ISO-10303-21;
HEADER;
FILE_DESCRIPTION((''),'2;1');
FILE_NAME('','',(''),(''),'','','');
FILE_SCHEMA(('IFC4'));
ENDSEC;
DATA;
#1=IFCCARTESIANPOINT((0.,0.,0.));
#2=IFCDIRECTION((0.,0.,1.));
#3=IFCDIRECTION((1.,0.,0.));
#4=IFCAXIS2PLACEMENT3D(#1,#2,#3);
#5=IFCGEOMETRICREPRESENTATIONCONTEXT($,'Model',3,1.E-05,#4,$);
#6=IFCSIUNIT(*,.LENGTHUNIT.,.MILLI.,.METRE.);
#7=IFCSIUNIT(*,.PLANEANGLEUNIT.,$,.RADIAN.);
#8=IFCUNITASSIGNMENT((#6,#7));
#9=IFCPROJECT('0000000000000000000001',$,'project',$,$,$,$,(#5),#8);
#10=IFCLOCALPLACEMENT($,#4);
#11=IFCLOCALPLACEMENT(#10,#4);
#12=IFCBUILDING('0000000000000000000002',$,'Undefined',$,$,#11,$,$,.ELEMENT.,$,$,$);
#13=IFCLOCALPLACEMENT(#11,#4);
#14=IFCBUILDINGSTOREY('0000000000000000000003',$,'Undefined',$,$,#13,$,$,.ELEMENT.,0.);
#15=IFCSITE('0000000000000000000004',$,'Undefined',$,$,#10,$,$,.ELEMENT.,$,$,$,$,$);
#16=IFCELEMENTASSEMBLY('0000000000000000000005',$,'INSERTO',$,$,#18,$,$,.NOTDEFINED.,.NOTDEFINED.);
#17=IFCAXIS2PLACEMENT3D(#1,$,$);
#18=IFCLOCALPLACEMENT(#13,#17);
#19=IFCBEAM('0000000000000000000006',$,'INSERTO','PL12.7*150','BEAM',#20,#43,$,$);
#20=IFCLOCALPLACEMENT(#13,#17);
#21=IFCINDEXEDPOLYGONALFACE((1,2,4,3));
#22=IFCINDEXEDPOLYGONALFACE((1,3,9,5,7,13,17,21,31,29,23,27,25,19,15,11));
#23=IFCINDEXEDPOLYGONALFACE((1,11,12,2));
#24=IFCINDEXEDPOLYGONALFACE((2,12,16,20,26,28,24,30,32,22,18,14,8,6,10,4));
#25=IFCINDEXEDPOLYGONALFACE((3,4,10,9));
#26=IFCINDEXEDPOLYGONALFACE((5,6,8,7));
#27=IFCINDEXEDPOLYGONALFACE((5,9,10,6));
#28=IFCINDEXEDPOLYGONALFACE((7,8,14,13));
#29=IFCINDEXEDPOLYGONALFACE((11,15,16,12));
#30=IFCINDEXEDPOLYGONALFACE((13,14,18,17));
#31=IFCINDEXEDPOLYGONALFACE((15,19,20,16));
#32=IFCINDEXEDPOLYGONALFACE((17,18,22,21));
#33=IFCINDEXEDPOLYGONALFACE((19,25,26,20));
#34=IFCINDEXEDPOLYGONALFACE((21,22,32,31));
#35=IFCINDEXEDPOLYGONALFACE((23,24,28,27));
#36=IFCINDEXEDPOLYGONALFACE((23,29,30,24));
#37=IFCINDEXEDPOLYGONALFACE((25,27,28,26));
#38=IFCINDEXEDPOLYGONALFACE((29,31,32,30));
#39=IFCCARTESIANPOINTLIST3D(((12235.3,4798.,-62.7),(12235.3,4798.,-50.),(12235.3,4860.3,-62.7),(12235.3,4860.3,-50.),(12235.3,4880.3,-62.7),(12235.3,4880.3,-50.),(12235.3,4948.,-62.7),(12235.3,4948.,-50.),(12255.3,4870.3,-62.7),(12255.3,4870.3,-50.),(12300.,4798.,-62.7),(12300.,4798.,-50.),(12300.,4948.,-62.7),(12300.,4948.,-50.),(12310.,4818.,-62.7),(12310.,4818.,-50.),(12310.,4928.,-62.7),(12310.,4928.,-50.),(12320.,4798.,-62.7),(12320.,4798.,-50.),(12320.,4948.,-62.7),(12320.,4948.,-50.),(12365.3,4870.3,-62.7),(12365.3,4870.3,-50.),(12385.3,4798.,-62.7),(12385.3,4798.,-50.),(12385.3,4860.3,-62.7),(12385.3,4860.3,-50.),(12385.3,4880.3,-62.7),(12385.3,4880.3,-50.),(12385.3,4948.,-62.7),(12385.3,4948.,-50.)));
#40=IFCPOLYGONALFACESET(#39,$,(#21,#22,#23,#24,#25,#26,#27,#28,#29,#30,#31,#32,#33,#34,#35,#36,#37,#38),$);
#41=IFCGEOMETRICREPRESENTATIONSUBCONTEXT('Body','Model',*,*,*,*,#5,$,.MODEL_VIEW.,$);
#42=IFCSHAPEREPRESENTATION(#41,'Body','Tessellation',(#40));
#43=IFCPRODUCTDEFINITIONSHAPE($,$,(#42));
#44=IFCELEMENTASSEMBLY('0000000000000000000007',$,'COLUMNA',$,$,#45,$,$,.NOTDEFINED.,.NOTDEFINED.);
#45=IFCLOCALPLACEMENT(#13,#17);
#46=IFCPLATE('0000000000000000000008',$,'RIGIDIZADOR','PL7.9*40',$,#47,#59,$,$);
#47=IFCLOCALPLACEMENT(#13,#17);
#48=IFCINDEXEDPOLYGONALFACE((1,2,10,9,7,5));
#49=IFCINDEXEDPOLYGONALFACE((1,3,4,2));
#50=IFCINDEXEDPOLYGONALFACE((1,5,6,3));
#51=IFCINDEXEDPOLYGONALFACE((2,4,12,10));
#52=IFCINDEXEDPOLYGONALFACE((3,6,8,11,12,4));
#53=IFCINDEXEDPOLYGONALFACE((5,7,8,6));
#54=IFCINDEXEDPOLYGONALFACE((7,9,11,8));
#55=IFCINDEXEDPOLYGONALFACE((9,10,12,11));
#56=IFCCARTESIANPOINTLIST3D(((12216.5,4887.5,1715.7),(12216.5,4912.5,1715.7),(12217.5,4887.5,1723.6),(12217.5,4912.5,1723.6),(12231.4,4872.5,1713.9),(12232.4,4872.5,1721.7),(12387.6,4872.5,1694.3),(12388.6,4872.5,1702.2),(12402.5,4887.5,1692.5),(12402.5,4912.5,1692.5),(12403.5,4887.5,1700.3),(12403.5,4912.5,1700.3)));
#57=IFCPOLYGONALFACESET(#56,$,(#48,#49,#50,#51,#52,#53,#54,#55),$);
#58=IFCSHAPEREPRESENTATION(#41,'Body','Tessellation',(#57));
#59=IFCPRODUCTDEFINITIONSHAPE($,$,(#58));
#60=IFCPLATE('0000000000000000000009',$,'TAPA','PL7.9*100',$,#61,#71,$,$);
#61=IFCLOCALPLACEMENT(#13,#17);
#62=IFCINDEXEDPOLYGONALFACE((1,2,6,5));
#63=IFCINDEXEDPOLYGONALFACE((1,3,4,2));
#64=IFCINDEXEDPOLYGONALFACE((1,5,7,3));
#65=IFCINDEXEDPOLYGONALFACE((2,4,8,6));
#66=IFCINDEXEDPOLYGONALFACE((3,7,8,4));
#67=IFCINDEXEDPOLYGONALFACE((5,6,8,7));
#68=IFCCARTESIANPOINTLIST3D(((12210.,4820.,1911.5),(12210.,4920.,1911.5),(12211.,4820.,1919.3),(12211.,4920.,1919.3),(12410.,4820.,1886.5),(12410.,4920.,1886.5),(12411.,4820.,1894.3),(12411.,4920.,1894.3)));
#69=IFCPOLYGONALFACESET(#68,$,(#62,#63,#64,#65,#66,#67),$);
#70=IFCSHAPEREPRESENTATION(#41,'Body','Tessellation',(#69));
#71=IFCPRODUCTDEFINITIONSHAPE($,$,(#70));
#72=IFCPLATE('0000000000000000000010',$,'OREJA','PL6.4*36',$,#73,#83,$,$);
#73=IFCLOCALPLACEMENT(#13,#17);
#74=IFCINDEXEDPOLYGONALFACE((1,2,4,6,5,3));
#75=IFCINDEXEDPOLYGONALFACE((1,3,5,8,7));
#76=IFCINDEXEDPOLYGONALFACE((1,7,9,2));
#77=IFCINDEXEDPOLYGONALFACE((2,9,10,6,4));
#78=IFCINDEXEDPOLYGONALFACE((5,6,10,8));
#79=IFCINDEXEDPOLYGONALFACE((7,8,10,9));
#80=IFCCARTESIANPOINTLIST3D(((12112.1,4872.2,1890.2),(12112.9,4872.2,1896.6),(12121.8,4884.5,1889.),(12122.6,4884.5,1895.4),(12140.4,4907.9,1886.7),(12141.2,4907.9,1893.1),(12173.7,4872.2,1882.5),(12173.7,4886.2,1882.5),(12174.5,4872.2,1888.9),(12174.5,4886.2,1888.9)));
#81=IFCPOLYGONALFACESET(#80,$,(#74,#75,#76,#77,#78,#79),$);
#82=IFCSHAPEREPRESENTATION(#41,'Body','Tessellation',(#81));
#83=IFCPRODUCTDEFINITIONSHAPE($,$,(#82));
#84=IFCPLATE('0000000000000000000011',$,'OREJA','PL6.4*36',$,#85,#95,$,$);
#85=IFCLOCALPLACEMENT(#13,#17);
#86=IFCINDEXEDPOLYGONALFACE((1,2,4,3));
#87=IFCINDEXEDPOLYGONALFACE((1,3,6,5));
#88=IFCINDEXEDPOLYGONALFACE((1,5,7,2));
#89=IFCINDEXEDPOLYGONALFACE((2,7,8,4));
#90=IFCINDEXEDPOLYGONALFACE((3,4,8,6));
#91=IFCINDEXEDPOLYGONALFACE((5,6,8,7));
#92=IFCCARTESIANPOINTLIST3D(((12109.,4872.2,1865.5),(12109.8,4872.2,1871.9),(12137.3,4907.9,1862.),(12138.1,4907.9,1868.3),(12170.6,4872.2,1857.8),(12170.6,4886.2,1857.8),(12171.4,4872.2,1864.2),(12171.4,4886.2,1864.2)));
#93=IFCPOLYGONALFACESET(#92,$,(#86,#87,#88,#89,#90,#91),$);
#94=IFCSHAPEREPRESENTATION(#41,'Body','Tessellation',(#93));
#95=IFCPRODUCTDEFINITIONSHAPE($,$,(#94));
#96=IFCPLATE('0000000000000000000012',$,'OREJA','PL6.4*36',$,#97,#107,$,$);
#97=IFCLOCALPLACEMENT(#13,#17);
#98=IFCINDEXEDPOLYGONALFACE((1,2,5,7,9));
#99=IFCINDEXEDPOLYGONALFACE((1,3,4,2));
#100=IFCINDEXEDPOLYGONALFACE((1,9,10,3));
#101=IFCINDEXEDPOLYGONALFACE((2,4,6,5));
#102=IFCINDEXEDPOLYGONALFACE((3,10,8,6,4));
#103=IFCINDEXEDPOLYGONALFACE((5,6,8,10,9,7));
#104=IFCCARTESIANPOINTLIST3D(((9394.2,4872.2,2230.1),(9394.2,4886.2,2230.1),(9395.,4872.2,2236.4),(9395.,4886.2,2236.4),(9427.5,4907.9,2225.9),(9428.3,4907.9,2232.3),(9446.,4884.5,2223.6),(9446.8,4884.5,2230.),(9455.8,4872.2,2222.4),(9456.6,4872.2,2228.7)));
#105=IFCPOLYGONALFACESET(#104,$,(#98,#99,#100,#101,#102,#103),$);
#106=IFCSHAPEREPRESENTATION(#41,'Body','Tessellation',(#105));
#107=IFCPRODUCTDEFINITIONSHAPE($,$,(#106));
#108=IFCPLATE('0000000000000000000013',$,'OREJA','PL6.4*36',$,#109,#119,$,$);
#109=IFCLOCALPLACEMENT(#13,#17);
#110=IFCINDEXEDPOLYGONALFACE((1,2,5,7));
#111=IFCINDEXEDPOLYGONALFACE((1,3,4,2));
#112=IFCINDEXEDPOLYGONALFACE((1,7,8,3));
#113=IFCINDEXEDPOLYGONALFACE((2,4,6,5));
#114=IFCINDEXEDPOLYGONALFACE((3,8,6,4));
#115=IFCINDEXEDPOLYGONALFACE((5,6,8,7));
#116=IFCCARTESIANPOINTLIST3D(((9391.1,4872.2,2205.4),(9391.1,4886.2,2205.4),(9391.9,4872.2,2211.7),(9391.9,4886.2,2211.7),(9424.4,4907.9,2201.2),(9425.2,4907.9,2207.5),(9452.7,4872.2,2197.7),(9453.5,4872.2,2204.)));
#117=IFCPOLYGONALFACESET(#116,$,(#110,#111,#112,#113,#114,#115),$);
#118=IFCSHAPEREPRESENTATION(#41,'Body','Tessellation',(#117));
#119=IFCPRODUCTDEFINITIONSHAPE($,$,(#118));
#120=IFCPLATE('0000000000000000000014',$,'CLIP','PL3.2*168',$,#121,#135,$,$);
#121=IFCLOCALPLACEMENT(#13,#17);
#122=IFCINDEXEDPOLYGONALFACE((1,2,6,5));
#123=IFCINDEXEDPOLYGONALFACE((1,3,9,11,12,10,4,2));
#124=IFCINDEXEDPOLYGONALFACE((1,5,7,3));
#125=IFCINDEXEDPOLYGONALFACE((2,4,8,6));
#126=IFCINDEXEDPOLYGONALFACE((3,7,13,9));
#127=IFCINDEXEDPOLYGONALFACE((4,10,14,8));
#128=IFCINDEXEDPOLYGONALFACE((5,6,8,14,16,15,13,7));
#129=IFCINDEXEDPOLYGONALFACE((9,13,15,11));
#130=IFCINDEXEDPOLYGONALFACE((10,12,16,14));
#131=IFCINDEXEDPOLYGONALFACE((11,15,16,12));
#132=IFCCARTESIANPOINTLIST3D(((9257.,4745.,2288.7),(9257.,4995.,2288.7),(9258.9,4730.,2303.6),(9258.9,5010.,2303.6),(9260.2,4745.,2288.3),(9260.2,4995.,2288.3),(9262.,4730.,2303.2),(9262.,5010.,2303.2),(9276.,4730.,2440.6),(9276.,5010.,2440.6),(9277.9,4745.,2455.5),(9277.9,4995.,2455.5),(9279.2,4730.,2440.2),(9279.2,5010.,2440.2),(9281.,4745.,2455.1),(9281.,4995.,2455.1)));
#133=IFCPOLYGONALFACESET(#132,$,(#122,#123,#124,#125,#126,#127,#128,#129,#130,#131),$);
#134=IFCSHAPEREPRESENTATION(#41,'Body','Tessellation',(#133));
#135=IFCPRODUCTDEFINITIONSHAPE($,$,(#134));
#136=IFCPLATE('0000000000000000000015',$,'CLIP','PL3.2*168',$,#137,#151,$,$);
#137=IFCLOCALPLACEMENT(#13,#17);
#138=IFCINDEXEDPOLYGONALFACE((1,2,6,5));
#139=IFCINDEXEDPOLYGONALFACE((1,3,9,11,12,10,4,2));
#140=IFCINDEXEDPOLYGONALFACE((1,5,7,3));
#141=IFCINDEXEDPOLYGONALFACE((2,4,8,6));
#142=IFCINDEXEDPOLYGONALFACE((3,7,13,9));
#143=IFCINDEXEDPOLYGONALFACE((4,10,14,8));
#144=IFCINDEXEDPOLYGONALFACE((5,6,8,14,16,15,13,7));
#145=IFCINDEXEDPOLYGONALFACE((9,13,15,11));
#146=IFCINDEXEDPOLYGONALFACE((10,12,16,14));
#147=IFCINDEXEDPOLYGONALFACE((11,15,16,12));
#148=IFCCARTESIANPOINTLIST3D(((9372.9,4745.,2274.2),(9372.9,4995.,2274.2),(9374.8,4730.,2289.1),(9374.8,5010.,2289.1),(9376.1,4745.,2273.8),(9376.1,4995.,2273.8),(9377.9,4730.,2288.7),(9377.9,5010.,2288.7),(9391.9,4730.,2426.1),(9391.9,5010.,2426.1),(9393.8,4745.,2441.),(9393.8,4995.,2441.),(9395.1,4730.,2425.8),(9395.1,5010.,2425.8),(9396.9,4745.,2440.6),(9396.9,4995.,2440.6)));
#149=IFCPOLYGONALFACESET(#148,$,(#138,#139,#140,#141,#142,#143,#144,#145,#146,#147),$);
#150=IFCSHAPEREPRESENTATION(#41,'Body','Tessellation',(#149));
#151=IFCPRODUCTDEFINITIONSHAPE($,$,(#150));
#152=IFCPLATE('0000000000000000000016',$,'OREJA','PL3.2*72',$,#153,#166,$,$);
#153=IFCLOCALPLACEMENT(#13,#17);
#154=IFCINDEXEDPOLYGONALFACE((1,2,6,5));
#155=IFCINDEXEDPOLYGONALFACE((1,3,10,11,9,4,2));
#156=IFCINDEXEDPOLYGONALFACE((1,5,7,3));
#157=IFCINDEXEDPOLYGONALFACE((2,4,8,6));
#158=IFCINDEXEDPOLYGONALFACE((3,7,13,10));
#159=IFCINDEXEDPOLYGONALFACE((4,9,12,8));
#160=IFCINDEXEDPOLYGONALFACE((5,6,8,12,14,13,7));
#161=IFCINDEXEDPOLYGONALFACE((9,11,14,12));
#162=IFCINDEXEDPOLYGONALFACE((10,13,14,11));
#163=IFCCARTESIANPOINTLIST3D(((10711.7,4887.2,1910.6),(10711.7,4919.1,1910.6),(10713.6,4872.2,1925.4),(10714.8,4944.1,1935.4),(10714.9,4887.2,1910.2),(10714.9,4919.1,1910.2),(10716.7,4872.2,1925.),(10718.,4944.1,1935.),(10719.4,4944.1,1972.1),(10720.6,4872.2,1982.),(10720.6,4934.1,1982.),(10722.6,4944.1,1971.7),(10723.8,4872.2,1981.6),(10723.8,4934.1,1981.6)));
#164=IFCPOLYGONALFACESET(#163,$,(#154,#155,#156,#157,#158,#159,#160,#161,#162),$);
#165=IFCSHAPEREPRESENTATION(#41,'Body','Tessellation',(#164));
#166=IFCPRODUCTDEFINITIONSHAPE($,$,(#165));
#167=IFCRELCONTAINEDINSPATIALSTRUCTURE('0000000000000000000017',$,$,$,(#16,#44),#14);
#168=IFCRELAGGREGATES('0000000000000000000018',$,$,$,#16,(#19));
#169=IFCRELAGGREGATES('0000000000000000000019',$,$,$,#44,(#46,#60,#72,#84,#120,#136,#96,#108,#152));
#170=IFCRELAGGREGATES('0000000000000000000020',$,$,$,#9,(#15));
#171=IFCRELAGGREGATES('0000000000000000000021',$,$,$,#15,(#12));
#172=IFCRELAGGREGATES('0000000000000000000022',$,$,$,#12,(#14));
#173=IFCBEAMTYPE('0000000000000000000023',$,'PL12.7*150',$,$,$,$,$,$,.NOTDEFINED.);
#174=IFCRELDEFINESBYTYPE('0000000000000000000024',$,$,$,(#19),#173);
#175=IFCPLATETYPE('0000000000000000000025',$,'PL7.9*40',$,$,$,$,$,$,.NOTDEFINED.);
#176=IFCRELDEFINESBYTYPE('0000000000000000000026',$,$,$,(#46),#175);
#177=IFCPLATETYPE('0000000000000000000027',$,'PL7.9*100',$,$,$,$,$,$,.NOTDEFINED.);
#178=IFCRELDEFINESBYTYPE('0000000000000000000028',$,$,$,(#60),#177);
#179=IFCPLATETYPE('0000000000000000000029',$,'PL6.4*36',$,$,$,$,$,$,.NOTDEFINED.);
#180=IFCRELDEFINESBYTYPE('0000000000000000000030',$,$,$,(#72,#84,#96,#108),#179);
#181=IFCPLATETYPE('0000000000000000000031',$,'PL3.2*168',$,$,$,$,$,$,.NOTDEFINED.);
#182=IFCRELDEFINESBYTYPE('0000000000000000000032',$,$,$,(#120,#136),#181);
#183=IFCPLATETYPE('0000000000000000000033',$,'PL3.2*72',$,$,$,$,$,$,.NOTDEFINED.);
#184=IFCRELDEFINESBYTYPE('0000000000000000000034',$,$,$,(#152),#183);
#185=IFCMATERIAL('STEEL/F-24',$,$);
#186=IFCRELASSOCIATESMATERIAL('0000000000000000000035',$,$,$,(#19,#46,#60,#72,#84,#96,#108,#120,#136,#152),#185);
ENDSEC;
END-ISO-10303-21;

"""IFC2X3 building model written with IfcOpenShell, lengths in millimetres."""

from ifc_helpers import new_model, si_unit, frame, origin_with_axes, origin_2d_with_axis, place, context, subcontext, project, spatial, polyline, rectangle, outline, extrude, boolean, material, type_object, element, aggregate, save


model = new_model("IFC2X3")

# Units and contexts
model_context = context("Model", 3, precision=1e-05, world=origin_with_axes())
body_context = subcontext(model_context, "Body", "Model", "MODEL_VIEW")
ifc_project = project(units=[si_unit("LENGTHUNIT", "METRE", prefix="MILLI"), si_unit("PLANEANGLEUNIT", "RADIAN")], contexts=[model_context])

# Site, building, storey
site_placement = place(None, origin_with_axes())
site = spatial("IfcSite", under=ifc_project, at=site_placement, Name="Undefined", CompositionType="ELEMENT")
building_placement = place(site_placement, origin_with_axes())
building = spatial("IfcBuilding", under=site, at=building_placement, Name="Undefined", CompositionType="ELEMENT")
storey_placement = place(building_placement, origin_with_axes())
storey = spatial("IfcBuildingStorey", under=building, at=storey_placement, Name="Undefined", CompositionType="ELEMENT", Elevation=0.0)

# Element assembly, beam
assembly_1_placement = place(storey_placement, origin_with_axes())
assembly_1 = element("IfcElementAssembly", 1, at=assembly_1_placement, inside=storey, Name="INSERTO", AssemblyPlace="NOTDEFINED", PredefinedType="NOTDEFINED")
ifc_material_1 = material(Name="STEEL/F-24")
beam_type_1 = type_object("IfcBeamType", Name="PL12.7*150", PredefinedType="NOTDEFINED")
beam_1_placement = place(assembly_1_placement, frame((12235.3, 4873.0, -56.3), z_axis=(0.0, 1.0, 0.0), x_axis=(1.0, 0.0, 0.0)))
beam_1 = element("IfcBeam", 2, at=beam_1_placement, type_object=beam_type_1, material=ifc_material_1, Name="INSERTO", Description="PL12.7*150", ObjectType="BEAM", context=body_context, shape_type="CSG", body=[
    boolean("DIFFERENCE", boolean("DIFFERENCE", boolean("DIFFERENCE", boolean("DIFFERENCE", extrude(rectangle(XDim=12.7, YDim=150.0, at=origin_2d_with_axis()), frame((150.0, 0.0, 0.0), z_axis=(-1.0, 0.0, 0.0), x_axis=(0.0, -1.0, 0.0)), (0.0, 0.0, 1.0), 150.0), extrude(outline(polyline([(0.0, 0.0), (20.0, 0.0), (10.0, 20.0), (0.0, 0.0)])), frame((0.0, -9.0, -12.7), z_axis=(0.0, 1.0, 0.0), x_axis=(0.0, 0.0, 1.0)), (0.0, 0.0, 1.0), 18.0)), extrude(outline(polyline([(0.0, 0.0), (20.0, 0.0), (10.0, 20.0), (0.0, 0.0)])), frame((150.0, 9.0, -12.7), z_axis=(0.0, -1.0, 0.0), x_axis=(0.0, 0.0, 1.0)), (0.0, 0.0, 1.0), 18.0)), extrude(outline(polyline([(0.0, 0.0), (20.0, 0.0), (10.0, 20.0), (0.0, 0.0)])), frame((64.7, -9.0, 75.0), z_axis=(0.0, 1.0, 0.0), x_axis=(1.0, 0.0, 0.0)), (0.0, 0.0, 1.0), 18.0)), extrude(outline(polyline([(0.0, 0.0), (20.0, 0.0), (10.0, 20.0), (0.0, 0.0)])), frame((64.7, 9.0, -75.0), z_axis=(0.0, -1.0, 0.0), x_axis=(1.0, 0.0, 0.0)), (0.0, 0.0, 1.0), 18.0)),
])
aggregate(assembly_1, [beam_1])

# Element assembly, plates
assembly_2_placement = place(storey_placement, origin_with_axes())
assembly_2 = element("IfcElementAssembly", 3, at=assembly_2_placement, inside=storey, Name="COLUMNA", AssemblyPlace="NOTDEFINED", PredefinedType="NOTDEFINED")
plate_type_1 = type_object("IfcPlateType", Name="PL7.9*40", PredefinedType="NOTDEFINED")
plate_1_placement = place(assembly_2_placement, frame((12217.0, 4912.5, 1719.6), z_axis=(0.124075, 0.0, 0.992273), x_axis=(0.0, -1.0, 0.0)))
plate_1 = element("IfcPlate", 4, at=plate_1_placement, type_object=plate_type_1, material=ifc_material_1, Name="RIGIDIZADOR", Description="PL7.9*40", context=body_context, shape_type="SweptSolid", body=[
    extrude(outline(polyline([(0.0, 0.0), (25.0, 0.0), (40.0, 15.0), (40.0, 172.5), (25.0, 187.5), (0.0, 187.5), (0.0, 0.0)])), frame((0.0, 0.0, -4.0), z_axis=(0.0, 0.0, 1.0), x_axis=(1.0, 0.0, 0.0)), (0.0, 0.0, 1.0), 7.9),
])
plate_type_2 = type_object("IfcPlateType", Name="PL7.9*100", PredefinedType="NOTDEFINED")
plate_2_placement = place(assembly_2_placement, frame((12210.5, 4870.0, 1915.4), z_axis=(-0.124075, 0.0, -0.992273), x_axis=(0.992273, 0.0, -0.124075)))
plate_2 = element("IfcPlate", 5, at=plate_2_placement, type_object=plate_type_2, material=ifc_material_1, Name="TAPA", Description="PL7.9*100", context=body_context, shape_type="SweptSolid", body=[
    extrude(outline(polyline([(0.0, -50.0), (0.0, 50.0), (201.6, 50.0), (201.6, -50.0), (0.0, -50.0)])), frame((0.0, 0.0, -4.0), z_axis=(0.0, 0.0, 1.0), x_axis=(1.0, 0.0, 0.0)), (0.0, 0.0, 1.0), 7.9),
])
plate_type_3 = type_object("IfcPlateType", Name="PL6.4*36", PredefinedType="NOTDEFINED")
plate_3_placement = place(assembly_2_placement, frame((12174.1, 4872.2, 1885.7), z_axis=(-0.124075, 0.0, -0.992273), x_axis=(-0.992273, 0.0, 0.124075)))
plate_3 = element("IfcPlate", 6, at=plate_3_placement, type_object=plate_type_3, material=ifc_material_1, Name="OREJA", Description="PL6.4*36", context=body_context, shape_type="SweptSolid", body=[
    extrude(outline(polyline([(0.0, 0.0), (62.1, 0.0), (52.3, 12.3), (33.6, 35.8), (0.0, 14.0), (0.0, 0.0)])), frame((0.0, 0.0, -3.2), z_axis=(0.0, 0.0, 1.0), x_axis=(1.0, 0.0, 0.0)), (0.0, 0.0, 1.0), 6.4),
])
plate_4_placement = place(assembly_2_placement, frame((12171.0, 4872.2, 1861.0), z_axis=(-0.124075, 0.0, -0.992273), x_axis=(-0.992273, 0.0, 0.124075)))
plate_4 = element("IfcPlate", 7, at=plate_4_placement, type_object=plate_type_3, material=ifc_material_1, Name="OREJA", Description="PL6.4*36", context=body_context, shape_type="SweptSolid", body=[
    extrude(outline(polyline([(0.0, 0.0), (62.1, 0.0), (33.6, 35.8), (0.0, 14.0), (0.0, 0.0)])), frame((0.0, 0.0, -3.2), z_axis=(0.0, 0.0, 1.0), x_axis=(1.0, 0.0, 0.0)), (0.0, 0.0, 1.0), 6.4),
])
plate_5_placement = place(assembly_2_placement, frame((9394.6, 4872.2, 2233.3), z_axis=(0.124075, 0.0, 0.992273), x_axis=(0.992273, 0.0, -0.124075)))
plate_5 = element("IfcPlate", 8, at=plate_5_placement, type_object=plate_type_3, material=ifc_material_1, Name="OREJA", Description="PL6.4*36", context=body_context, shape_type="SweptSolid", body=[
    extrude(outline(polyline([(0.0, 0.0), (62.1, 0.0), (52.3, 12.3), (33.6, 35.8), (0.0, 14.0), (0.0, 0.0)])), frame((0.0, 0.0, -3.2), z_axis=(0.0, 0.0, 1.0), x_axis=(1.0, 0.0, 0.0)), (0.0, 0.0, 1.0), 6.4),
])
plate_6_placement = place(assembly_2_placement, frame((9391.5, 4872.2, 2208.5), z_axis=(0.124075, 0.0, 0.992273), x_axis=(0.992273, 0.0, -0.124075)))
plate_6 = element("IfcPlate", 9, at=plate_6_placement, type_object=plate_type_3, material=ifc_material_1, Name="OREJA", Description="PL6.4*36", context=body_context, shape_type="SweptSolid", body=[
    extrude(outline(polyline([(0.0, 0.0), (62.1, 0.0), (33.6, 35.8), (0.0, 14.0), (0.0, 0.0)])), frame((0.0, 0.0, -3.2), z_axis=(0.0, 0.0, 1.0), x_axis=(1.0, 0.0, 0.0)), (0.0, 0.0, 1.0), 6.4),
])
plate_type_4 = type_object("IfcPlateType", Name="PL3.2*168", PredefinedType="NOTDEFINED")
plate_7_placement = place(assembly_2_placement, frame((9279.5, 5010.0, 2455.3), z_axis=(0.992275, 0.0, -0.124059), x_axis=(0.0, -1.0, 0.0)))
plate_7 = element("IfcPlate", 10, at=plate_7_placement, type_object=plate_type_4, material=ifc_material_1, Name="CLIP", Description="PL3.2*168", context=body_context, shape_type="SweptSolid", body=[
    extrude(outline(polyline([(0.0, 15.0), (15.0, 0.0), (265.0, 0.0), (280.0, 15.0), (280.0, 153.1), (265.0, 168.1), (15.0, 168.1), (0.0, 153.1), (0.0, 15.0)])), frame((0.0, 0.0, -1.6), z_axis=(0.0, 0.0, 1.0), x_axis=(1.0, 0.0, 0.0)), (0.0, 0.0, 1.0), 3.2),
])
plate_8_placement = place(assembly_2_placement, frame((9395.4, 5010.0, 2440.8), z_axis=(0.992271, 0.0, -0.124089), x_axis=(0.0, -1.0, 0.0)))
plate_8 = element("IfcPlate", 11, at=plate_8_placement, type_object=plate_type_4, material=ifc_material_1, Name="CLIP", Description="PL3.2*168", context=body_context, shape_type="SweptSolid", body=[
    extrude(outline(polyline([(0.0, 15.0), (15.0, 0.0), (265.0, 0.0), (280.0, 15.0), (280.0, 153.1), (265.0, 168.1), (15.0, 168.1), (0.0, 153.1), (0.0, 15.0)])), frame((0.0, 0.0, -1.6), z_axis=(0.0, 0.0, 1.0), x_axis=(1.0, 0.0, 0.0)), (0.0, 0.0, 1.0), 3.2),
])
plate_type_5 = type_object("IfcPlateType", Name="PL3.2*72", PredefinedType="NOTDEFINED")
plate_9_placement = place(assembly_2_placement, frame((10713.3, 4872.2, 1910.4), z_axis=(0.992251, 0.0, -0.124252), x_axis=(0.0, 1.0, 0.0)))
plate_9 = element("IfcPlate", 12, at=plate_9_placement, type_object=plate_type_5, material=ifc_material_1, Name="OREJA", Description="PL3.2*72", context=body_context, shape_type="SweptSolid", body=[
    extrude(outline(polyline([(0.0, 15.0), (15.0, 0.0), (47.0, 0.0), (72.0, 25.0), (72.0, 62.0), (62.0, 72.0), (0.0, 72.0), (0.0, 15.0)])), frame((0.0, 0.0, -1.6), z_axis=(0.0, 0.0, 1.0), x_axis=(1.0, 0.0, 0.0)), (0.0, 0.0, 1.0), 3.2),
])

aggregate(assembly_2, [plate_1, plate_2, plate_3, plate_4, plate_7, plate_8, plate_5, plate_6, plate_9])

save(model, "model.ifc")
